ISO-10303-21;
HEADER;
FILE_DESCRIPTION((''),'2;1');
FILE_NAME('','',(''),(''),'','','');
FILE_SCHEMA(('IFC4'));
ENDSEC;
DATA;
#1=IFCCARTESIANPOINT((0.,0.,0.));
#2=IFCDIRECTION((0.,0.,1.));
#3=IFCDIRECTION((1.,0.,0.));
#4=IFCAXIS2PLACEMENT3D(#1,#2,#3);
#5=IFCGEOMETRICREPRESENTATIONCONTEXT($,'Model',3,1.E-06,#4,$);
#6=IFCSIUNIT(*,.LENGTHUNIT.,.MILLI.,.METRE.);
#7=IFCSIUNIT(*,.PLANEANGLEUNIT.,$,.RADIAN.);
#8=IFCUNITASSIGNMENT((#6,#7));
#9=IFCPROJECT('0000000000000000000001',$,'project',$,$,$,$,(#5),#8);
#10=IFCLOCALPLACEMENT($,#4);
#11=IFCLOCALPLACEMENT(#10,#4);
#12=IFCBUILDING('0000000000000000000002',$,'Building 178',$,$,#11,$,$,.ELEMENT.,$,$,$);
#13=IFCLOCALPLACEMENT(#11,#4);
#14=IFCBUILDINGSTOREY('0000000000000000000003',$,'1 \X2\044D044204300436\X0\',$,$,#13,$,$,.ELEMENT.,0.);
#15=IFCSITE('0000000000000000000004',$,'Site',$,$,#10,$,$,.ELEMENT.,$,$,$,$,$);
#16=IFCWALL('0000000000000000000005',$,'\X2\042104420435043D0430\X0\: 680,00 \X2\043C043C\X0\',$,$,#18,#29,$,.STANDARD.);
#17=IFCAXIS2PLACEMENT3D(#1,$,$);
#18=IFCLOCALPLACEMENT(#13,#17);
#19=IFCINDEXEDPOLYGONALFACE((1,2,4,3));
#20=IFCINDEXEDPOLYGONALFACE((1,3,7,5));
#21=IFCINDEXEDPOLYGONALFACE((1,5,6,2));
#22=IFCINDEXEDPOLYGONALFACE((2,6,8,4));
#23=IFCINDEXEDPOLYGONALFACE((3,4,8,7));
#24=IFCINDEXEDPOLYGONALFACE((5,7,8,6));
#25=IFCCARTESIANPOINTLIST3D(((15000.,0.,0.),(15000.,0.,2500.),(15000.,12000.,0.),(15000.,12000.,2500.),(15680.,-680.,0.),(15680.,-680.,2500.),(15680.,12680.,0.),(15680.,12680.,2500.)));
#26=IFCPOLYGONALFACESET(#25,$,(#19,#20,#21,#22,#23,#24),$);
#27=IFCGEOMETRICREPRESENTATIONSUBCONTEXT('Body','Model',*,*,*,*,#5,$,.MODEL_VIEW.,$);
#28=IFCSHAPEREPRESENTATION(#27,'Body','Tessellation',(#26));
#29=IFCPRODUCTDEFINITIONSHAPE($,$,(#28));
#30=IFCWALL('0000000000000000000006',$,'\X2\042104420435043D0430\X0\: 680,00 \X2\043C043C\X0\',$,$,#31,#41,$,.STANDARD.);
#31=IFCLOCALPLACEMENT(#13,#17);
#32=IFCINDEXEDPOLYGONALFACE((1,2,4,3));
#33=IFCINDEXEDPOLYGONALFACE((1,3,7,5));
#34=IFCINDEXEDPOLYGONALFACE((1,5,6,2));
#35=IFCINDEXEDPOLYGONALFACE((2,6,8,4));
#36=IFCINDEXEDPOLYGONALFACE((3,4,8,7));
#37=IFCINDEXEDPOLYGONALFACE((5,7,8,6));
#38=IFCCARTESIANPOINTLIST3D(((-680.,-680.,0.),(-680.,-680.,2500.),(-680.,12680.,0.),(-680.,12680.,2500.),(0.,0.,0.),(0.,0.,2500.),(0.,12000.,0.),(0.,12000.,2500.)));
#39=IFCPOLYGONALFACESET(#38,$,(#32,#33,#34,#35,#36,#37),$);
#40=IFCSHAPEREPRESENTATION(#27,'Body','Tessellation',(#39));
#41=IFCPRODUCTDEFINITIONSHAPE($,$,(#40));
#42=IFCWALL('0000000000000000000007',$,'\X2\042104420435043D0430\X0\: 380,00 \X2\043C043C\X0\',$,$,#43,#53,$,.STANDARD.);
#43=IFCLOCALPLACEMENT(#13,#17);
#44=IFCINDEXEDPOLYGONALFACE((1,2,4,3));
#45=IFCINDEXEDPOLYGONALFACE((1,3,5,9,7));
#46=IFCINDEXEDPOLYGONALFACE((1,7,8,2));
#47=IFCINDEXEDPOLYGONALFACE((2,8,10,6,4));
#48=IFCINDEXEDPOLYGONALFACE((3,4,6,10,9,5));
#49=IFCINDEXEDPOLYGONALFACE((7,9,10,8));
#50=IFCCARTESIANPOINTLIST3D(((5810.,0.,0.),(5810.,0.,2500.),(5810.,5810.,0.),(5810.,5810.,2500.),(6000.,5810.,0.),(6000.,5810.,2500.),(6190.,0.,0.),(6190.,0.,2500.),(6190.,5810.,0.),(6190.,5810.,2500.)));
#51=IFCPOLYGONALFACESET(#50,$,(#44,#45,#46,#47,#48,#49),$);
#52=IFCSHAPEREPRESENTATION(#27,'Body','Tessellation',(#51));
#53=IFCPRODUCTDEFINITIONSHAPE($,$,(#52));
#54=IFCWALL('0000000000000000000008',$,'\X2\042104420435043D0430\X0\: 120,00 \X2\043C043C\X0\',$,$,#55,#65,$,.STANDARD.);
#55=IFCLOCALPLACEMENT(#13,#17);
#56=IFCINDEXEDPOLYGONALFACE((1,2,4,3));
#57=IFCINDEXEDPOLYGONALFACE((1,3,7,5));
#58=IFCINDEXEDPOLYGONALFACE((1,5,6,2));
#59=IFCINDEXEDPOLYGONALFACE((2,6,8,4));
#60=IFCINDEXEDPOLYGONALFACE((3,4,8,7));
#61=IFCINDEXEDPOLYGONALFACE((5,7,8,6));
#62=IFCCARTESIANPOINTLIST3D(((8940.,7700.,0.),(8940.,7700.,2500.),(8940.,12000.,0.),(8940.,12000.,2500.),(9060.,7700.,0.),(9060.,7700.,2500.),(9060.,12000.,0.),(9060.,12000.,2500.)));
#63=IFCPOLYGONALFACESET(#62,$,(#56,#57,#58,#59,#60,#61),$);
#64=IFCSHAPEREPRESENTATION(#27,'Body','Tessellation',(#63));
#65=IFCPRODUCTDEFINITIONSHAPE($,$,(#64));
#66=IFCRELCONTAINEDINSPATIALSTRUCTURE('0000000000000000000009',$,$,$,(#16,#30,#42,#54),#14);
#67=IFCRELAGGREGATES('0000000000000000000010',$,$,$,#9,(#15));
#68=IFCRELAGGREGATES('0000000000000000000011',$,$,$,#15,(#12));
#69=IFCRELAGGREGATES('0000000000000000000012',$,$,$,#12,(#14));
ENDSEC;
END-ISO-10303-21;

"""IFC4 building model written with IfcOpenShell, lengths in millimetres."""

from ifc_helpers import new_model, si_unit, frame, origin_with_axes, place, context, subcontext, project, spatial, line, indexed_curve, outline, extrude, source, transform, mapped, element, save


model = new_model("IFC4")

# Units and contexts
model_context = context("Model", 3, precision=1e-06, world=origin_with_axes())
body_context = subcontext(model_context, "Body", "Model", "MODEL_VIEW")
ifc_project = project(units=[si_unit("LENGTHUNIT", "METRE", prefix="MILLI"), si_unit("PLANEANGLEUNIT", "RADIAN")], contexts=[model_context])

# Site, building, storey
site_placement = place(None, origin_with_axes())
site = spatial("IfcSite", under=ifc_project, at=site_placement, Name="Site", CompositionType="ELEMENT")
building_placement = place(site_placement, origin_with_axes())
building = spatial("IfcBuilding", under=site, at=building_placement, Name="Building 178", CompositionType="ELEMENT")
storey_placement = place(building_placement, origin_with_axes())
storey = spatial("IfcBuildingStorey", under=building, at=storey_placement, Name="1 этаж", CompositionType="ELEMENT", Elevation=0.0)

# Walls
shared_shape_1 = source(origin_with_axes(), body_context, "Body", "SweptSolid", [
    extrude(outline(indexed_curve([(-340.0, -340.0), (13020.0, -340.0), (12340.0, 340.0), (340.0, 340.0)], segments=[line(1, 2), line(2, 3), line(3, 4), line(4, 1)])), origin_with_axes(), (0.0, 0.0, 1.0), 2500.0),
])
for number, where, z_axis, x_axis, name in (
    (1, (15340.0, -340.0, 0.0), (0.0, 0.0, 1.0), (0.0, 1.0, 0.0), "Стена: 680,00 мм"),
    (2, (-340.0, 12340.0, 0.0), (0.0, 0.0, 1.0), (0.0, -1.0, 0.0), "Стена: 680,00 мм"),
):
    element("IfcWall", number, at=place(storey_placement, frame(where, z_axis=z_axis, x_axis=x_axis)), inside=storey, Name=name, PredefinedType="STANDARD", context=body_context, shape_type="MappedRepresentation", body=[
        mapped(shared_shape_1, transform((0.0, 0.0, 0.0), x_axis=(1.0, 0.0, 0.0), y_axis=(0.0, 1.0, 0.0), z_axis=(0.0, 0.0, 1.0), scale=1.0)),
    ])
shared_shape_2 = source(origin_with_axes(), body_context, "Body", "SweptSolid", [
    extrude(outline(indexed_curve([(0.0, -190.0), (5810.0, -190.0), (5810.0, 0.0), (5810.0, 190.0), (0.0, 190.0)], segments=[line(1, 2), line(2, 3), line(3, 4), line(4, 5), line(5, 1)])), origin_with_axes(), (0.0, 0.0, 1.0), 2500.0),
])
wall_1_placement = place(storey_placement, frame((6000.0, 0.0, 0.0), z_axis=(0.0, 0.0, 1.0), x_axis=(0.0, 1.0, 0.0)))
element("IfcWall", 3, at=wall_1_placement, inside=storey, Name="Стена: 380,00 мм", PredefinedType="STANDARD", context=body_context, shape_type="MappedRepresentation", body=[
    mapped(shared_shape_2, transform((0.0, 0.0, 0.0), x_axis=(1.0, 0.0, 0.0), y_axis=(0.0, 1.0, 0.0), z_axis=(0.0, 0.0, 1.0), scale=1.0)),
])
shared_shape_3 = source(origin_with_axes(), body_context, "Body", "SweptSolid", [
    extrude(outline(indexed_curve([(0.0, -60.0), (4300.0, -60.0), (4300.0, 60.0), (0.0, 60.0)], segments=[line(1, 2), line(2, 3), line(3, 4), line(4, 1)])), origin_with_axes(), (0.0, 0.0, 1.0), 2500.0),
])
wall_2_placement = place(storey_placement, frame((9000.0, 7700.0, 0.0), z_axis=(0.0, 0.0, 1.0), x_axis=(0.0, 1.0, 0.0)))
element("IfcWall", 4, at=wall_2_placement, inside=storey, Name="Стена: 120,00 мм", PredefinedType="STANDARD", context=body_context, shape_type="MappedRepresentation", body=[
    mapped(shared_shape_3, transform((0.0, 0.0, 0.0), x_axis=(1.0, 0.0, 0.0), y_axis=(0.0, 1.0, 0.0), z_axis=(0.0, 0.0, 1.0), scale=1.0)),
])

save(model, "model.ifc")
